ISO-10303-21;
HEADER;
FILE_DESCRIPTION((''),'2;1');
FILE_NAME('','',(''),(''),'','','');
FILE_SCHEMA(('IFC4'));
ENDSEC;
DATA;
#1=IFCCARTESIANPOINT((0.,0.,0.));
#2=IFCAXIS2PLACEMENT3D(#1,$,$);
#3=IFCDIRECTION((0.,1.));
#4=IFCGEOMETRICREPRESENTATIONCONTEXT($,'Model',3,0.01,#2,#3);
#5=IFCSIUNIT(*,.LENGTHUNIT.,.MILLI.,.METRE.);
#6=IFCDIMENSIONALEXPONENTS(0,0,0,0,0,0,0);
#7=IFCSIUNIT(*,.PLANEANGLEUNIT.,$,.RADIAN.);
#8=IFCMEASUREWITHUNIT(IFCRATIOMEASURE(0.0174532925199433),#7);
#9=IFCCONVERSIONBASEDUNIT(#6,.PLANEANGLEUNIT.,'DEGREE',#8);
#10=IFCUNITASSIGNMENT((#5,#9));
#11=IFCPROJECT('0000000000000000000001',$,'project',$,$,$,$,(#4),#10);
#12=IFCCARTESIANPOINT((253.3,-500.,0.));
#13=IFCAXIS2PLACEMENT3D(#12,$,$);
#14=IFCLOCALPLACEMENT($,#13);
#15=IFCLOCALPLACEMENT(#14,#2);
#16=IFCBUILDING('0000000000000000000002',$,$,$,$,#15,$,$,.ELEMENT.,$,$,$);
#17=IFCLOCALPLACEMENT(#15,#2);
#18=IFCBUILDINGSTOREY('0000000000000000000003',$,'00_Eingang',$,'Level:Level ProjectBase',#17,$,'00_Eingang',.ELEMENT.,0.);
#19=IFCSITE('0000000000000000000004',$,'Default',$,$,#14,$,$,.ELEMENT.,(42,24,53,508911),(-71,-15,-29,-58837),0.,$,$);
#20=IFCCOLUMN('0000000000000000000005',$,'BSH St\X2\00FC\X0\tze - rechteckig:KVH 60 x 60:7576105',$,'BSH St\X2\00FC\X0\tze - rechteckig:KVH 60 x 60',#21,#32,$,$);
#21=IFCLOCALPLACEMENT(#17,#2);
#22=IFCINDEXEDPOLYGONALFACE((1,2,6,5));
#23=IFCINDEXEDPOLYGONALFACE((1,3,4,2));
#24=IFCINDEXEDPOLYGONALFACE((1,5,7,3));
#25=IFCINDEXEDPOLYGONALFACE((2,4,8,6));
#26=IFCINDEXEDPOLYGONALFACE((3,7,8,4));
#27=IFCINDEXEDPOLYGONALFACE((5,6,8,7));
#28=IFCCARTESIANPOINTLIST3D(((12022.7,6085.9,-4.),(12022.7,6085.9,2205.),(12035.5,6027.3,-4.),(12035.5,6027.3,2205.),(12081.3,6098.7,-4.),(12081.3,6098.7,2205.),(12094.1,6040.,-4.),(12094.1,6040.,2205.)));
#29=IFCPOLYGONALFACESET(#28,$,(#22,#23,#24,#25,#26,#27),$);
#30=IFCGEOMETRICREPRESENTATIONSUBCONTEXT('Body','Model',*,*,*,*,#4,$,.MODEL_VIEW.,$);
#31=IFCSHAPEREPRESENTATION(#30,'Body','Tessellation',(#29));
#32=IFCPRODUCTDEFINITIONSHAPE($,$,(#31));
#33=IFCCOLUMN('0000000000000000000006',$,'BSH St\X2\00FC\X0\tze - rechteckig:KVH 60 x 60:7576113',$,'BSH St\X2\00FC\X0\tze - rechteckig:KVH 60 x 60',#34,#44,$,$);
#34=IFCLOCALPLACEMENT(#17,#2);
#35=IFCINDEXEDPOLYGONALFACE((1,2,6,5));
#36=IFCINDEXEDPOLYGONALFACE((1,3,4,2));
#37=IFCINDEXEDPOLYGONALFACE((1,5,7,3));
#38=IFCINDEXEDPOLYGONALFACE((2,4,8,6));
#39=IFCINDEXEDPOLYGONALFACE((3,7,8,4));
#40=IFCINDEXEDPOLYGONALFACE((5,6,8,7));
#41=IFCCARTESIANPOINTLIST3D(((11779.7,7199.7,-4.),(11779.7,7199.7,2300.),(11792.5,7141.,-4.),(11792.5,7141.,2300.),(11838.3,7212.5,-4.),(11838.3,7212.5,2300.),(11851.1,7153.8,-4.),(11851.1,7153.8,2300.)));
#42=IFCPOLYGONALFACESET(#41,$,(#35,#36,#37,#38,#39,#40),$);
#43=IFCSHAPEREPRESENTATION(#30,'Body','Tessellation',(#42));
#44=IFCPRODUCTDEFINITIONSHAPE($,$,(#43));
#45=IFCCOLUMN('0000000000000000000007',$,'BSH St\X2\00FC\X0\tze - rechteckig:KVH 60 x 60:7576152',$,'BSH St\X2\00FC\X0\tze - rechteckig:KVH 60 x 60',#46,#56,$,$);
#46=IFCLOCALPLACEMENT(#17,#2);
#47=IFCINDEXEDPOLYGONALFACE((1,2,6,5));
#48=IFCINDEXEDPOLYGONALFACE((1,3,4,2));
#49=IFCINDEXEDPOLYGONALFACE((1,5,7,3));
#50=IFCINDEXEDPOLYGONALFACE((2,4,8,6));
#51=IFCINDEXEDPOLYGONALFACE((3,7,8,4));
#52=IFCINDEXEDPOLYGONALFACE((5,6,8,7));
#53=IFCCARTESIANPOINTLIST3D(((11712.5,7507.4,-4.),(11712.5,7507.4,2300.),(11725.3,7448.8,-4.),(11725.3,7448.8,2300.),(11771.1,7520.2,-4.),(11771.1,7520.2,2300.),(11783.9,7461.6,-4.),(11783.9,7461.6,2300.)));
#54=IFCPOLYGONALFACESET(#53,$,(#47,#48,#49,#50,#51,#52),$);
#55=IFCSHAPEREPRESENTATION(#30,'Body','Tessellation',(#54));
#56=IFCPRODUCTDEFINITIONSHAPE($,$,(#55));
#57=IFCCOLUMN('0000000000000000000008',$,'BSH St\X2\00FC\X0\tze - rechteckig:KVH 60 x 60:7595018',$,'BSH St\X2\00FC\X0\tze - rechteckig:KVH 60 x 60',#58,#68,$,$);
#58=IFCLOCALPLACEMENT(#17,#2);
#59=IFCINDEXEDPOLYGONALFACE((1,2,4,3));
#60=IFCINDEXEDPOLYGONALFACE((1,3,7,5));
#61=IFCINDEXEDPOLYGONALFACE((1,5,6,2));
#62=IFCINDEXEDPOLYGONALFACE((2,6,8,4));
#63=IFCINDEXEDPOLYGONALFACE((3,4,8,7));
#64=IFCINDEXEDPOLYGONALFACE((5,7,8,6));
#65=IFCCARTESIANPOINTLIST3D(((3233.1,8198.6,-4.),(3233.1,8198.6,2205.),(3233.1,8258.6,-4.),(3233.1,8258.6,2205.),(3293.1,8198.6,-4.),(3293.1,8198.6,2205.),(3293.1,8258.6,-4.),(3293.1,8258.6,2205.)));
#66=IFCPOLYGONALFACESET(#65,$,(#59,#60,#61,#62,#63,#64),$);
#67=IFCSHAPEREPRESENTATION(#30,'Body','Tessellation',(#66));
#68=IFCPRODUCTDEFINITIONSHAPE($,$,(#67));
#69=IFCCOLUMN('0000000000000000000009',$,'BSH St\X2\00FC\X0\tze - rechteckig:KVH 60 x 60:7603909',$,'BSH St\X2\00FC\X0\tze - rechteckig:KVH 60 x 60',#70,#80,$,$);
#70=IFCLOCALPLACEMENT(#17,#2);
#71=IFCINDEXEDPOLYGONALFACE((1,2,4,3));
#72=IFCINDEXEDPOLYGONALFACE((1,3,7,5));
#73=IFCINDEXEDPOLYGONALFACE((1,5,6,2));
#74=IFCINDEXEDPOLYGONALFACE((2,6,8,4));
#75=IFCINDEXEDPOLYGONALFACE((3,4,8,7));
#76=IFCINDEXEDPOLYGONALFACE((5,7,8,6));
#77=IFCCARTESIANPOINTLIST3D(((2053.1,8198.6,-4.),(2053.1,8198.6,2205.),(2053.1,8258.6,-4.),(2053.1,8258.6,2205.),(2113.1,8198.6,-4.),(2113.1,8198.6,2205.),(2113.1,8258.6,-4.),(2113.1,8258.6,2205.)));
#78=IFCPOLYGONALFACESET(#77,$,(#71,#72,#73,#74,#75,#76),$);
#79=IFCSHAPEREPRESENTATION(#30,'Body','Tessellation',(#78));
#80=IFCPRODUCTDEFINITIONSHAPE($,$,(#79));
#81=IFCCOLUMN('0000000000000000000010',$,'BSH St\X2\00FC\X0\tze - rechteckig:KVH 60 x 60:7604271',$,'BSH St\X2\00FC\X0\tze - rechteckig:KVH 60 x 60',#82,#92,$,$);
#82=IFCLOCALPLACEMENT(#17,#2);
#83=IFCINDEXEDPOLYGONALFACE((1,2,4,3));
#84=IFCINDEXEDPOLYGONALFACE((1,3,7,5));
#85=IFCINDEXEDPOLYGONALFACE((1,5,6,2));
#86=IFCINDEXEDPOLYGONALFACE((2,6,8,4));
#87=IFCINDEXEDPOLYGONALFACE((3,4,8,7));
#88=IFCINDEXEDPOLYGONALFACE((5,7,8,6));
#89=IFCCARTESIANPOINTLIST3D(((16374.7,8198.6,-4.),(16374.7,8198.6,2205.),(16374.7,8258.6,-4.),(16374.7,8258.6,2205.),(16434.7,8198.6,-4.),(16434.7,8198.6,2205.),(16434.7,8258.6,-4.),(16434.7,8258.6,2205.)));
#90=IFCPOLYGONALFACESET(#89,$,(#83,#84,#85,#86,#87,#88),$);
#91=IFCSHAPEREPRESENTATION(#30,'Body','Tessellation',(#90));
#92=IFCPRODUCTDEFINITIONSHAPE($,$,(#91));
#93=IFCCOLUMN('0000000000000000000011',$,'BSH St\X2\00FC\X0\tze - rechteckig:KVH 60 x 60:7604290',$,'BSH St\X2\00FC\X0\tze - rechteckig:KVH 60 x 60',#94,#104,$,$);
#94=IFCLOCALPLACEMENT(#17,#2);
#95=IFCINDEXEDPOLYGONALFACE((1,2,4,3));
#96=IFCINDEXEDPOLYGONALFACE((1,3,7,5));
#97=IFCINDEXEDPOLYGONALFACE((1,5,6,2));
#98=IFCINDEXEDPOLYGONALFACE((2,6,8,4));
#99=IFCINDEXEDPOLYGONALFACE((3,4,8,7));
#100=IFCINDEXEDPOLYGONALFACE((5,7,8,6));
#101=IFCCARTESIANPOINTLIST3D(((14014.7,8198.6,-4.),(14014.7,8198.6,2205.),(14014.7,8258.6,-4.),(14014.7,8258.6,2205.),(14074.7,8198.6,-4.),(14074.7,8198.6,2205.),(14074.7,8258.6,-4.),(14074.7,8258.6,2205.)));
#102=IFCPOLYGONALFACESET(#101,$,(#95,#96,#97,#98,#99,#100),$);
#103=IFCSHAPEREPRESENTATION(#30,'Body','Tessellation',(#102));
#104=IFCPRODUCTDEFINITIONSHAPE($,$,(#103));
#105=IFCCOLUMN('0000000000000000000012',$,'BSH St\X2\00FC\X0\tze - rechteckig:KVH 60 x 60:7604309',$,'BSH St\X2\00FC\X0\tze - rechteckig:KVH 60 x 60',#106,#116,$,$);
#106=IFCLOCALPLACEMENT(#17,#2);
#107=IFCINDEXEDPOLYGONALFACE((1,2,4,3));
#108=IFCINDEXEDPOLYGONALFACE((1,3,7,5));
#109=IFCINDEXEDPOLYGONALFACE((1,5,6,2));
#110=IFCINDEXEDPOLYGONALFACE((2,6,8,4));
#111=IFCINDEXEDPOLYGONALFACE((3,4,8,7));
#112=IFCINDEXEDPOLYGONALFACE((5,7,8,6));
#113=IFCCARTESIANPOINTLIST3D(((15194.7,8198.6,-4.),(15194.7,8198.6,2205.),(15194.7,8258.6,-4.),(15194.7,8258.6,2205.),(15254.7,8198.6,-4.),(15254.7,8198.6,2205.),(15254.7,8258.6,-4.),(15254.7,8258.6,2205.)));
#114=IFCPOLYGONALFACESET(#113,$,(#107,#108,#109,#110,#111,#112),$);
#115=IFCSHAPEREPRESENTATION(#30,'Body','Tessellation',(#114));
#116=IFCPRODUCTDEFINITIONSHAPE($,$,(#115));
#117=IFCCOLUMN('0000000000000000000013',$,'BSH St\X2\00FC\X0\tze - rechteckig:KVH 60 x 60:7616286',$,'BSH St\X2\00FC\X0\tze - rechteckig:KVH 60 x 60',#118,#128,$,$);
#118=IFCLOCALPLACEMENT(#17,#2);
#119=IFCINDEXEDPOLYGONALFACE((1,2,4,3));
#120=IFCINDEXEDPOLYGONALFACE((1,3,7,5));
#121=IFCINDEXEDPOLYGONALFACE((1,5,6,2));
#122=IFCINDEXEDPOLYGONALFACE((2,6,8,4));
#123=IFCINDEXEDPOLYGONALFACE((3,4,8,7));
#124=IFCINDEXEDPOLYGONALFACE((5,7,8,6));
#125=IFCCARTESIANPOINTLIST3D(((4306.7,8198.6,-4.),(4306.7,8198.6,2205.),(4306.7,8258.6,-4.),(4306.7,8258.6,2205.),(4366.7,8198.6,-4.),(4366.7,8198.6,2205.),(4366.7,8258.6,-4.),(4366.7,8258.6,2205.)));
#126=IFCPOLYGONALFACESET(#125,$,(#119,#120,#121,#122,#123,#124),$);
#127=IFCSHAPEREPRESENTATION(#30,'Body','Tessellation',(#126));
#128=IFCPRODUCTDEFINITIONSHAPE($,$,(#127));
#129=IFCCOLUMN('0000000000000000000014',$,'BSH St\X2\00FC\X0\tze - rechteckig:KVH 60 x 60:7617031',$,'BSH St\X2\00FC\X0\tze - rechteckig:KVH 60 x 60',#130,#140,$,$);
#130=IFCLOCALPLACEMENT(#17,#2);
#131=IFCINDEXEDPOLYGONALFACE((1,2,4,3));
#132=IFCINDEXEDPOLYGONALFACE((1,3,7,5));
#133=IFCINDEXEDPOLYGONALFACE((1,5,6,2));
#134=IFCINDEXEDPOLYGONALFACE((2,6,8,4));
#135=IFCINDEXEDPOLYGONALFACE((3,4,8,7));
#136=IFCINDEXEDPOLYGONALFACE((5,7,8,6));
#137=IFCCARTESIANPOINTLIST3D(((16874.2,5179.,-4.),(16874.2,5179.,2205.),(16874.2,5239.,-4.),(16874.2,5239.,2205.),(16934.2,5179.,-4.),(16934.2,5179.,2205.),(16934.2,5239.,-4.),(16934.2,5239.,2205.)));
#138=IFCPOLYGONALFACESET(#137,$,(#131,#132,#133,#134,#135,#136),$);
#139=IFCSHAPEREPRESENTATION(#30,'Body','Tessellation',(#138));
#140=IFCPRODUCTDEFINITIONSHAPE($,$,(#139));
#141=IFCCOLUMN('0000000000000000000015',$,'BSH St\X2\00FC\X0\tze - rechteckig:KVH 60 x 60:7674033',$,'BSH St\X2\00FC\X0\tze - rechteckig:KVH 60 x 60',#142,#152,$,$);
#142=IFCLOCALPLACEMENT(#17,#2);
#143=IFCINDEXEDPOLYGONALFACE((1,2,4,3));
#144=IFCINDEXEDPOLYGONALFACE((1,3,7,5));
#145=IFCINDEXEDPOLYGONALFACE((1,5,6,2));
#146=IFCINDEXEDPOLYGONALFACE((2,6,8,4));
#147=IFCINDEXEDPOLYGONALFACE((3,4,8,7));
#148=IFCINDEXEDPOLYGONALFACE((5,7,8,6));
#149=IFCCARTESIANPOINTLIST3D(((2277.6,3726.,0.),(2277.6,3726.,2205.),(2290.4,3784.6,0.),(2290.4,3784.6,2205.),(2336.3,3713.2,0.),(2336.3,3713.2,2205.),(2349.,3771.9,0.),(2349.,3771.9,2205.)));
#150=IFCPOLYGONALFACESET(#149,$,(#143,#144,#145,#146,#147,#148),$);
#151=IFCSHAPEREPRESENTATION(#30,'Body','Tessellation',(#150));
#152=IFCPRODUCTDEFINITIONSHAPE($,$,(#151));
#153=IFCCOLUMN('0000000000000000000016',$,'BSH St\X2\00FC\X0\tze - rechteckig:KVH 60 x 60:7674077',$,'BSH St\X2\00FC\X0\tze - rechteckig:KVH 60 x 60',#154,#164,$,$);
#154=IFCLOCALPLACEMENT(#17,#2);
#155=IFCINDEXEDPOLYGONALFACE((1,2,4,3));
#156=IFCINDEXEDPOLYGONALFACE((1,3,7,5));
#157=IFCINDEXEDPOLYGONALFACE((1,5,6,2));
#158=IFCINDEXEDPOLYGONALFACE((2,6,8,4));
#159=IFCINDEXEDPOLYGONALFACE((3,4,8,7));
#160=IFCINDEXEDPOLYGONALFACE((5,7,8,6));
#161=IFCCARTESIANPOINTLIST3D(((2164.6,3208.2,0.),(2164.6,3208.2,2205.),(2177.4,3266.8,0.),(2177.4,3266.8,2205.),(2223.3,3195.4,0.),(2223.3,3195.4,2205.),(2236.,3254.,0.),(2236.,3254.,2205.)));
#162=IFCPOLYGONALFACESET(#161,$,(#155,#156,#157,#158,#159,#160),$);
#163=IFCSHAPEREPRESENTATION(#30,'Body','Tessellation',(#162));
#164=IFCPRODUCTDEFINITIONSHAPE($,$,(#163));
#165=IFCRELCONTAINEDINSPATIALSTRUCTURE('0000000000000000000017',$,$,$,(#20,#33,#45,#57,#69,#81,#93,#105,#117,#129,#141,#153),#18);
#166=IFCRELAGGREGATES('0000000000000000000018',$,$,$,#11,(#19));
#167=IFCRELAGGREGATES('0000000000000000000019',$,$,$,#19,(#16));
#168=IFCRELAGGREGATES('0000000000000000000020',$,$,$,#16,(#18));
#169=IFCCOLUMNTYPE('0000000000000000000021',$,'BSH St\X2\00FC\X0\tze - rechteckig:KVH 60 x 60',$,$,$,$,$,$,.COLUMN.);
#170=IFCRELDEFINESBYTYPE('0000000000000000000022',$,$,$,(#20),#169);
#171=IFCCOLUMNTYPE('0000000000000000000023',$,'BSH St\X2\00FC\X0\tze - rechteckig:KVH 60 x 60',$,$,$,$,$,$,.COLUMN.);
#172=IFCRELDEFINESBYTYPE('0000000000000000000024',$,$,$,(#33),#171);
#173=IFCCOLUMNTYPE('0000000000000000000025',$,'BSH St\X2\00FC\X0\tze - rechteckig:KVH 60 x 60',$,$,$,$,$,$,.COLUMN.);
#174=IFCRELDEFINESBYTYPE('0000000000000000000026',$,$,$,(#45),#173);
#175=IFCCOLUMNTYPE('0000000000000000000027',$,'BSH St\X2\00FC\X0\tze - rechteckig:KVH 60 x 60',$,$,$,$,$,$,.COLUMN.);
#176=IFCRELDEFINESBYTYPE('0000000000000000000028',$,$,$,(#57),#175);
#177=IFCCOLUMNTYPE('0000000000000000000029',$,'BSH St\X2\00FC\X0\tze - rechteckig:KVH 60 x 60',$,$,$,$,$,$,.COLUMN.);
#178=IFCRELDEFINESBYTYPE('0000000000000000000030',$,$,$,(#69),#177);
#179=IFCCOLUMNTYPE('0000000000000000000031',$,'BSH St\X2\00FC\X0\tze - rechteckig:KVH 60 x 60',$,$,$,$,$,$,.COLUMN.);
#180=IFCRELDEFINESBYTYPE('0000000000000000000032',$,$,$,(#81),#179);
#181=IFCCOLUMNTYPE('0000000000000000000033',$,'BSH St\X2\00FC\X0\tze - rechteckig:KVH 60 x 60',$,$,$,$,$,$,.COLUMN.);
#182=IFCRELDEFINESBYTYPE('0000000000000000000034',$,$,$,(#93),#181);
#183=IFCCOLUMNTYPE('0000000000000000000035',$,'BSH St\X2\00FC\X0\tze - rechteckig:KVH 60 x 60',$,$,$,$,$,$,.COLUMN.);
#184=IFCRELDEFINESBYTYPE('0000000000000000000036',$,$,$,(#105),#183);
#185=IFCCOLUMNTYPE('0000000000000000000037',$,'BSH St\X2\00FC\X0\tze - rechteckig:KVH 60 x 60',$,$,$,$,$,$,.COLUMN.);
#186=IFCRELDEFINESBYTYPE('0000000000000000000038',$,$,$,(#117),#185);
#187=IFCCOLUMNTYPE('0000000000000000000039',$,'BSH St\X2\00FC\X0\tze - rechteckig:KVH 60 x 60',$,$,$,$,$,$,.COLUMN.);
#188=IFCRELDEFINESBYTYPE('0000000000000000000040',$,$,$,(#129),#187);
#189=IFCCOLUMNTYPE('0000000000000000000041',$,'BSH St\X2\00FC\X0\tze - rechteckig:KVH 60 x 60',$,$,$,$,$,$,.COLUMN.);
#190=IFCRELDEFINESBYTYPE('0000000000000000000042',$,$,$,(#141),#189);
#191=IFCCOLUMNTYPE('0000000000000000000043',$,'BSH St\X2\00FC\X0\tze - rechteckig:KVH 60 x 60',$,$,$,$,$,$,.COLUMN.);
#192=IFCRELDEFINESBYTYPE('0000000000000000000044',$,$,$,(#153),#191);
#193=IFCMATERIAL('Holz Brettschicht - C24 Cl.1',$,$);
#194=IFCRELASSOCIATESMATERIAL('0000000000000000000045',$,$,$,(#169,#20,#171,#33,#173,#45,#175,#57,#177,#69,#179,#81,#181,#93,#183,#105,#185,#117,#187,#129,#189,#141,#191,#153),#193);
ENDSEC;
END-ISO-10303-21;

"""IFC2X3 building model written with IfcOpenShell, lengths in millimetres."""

from ifc_helpers import new_model, entity, si_unit, converted_unit, direction, frame, frame_2d, origin, origin_2d_with_axis, place, context, subcontext, project, spatial, rectangle, extrude, source, transform, mapped, material, type_object, type_shapes, element, save


model = new_model("IFC2X3")

# Units and contexts
model_context = context("Model", 3, precision=0.01, world=origin(), true_north=direction((0.0, 1.0)))
body_context = subcontext(model_context, "Body", "Model", "MODEL_VIEW")
ifc_project = project(units=[si_unit("LENGTHUNIT", "METRE", prefix="MILLI"), converted_unit("PLANEANGLEUNIT", "DEGREE", entity("IfcRatioMeasure", 0.0174532925199433), si_unit("PLANEANGLEUNIT", "RADIAN"), dimensions=[0, 0, 0, 0, 0, 0, 0])], contexts=[model_context])

# Site, building, storey
site_placement = place(None, frame((253.3, -500.0, 0.0)))
site = spatial("IfcSite", under=ifc_project, at=site_placement, Name="Default", CompositionType="ELEMENT", RefLatitude=(42, 24, 53, 508911), RefLongitude=(-71, -15, -29, -58837), RefElevation=0.0)
building_placement = place(site_placement, origin())
building = spatial("IfcBuilding", under=site, at=building_placement, CompositionType="ELEMENT")
storey_placement = place(building_placement, origin())
storey = spatial("IfcBuildingStorey", under=building, at=storey_placement, Name="00_Eingang", ObjectType="Level:Level ProjectBase", LongName="00_Eingang", CompositionType="ELEMENT", Elevation=0.0)

# Columns
ifc_material_1 = material(Name="Holz Brettschicht - C24 Cl.1")
column_type_1 = type_object("IfcColumnType", Name="BSH Stütze - rechteckig:KVH 60 x 60", PredefinedType="COLUMN", material=ifc_material_1)
shared_shape_1 = source(origin(), body_context, "Body", "SweptSolid", [
    extrude(rectangle(XDim=60.0, YDim=60.0, at=origin_2d_with_axis()), frame((12058.4, 6063.0, -4.0), z_axis=(0.0, 0.0, 1.0), x_axis=(-0.213201, 0.977008, 0.0)), (0.0, 0.0, 1.0), 2209.0),
])
type_shapes(column_type_1, [shared_shape_1])
column_1_placement = place(storey_placement, origin())
element("IfcColumn", 1, at=column_1_placement, inside=storey, type_object=column_type_1, material=ifc_material_1, Name="BSH Stütze - rechteckig:KVH 60 x 60:7576105", ObjectType="BSH Stütze - rechteckig:KVH 60 x 60", context=body_context, shape_type="MappedRepresentation", body=[
    mapped(shared_shape_1, transform((0.0, 0.0, 0.0), scale=1.0)),
])
column_type_2 = type_object("IfcColumnType", Name="BSH Stütze - rechteckig:KVH 60 x 60", PredefinedType="COLUMN", material=ifc_material_1)
shared_shape_2 = source(origin(), body_context, "Body", "SweptSolid", [
    extrude(rectangle(XDim=60.0, YDim=60.0, at=frame_2d((0.0, 0.0), x_axis=(1.0, 0.0))), frame((11815.4, 7176.8, -4.0), z_axis=(0.0, 0.0, 1.0), x_axis=(-0.213201, 0.977008, 0.0)), (0.0, 0.0, 1.0), 2304.0),
])
type_shapes(column_type_2, [shared_shape_2])
column_2_placement = place(storey_placement, origin())
element("IfcColumn", 2, at=column_2_placement, inside=storey, type_object=column_type_2, material=ifc_material_1, Name="BSH Stütze - rechteckig:KVH 60 x 60:7576113", ObjectType="BSH Stütze - rechteckig:KVH 60 x 60", context=body_context, shape_type="MappedRepresentation", body=[
    mapped(shared_shape_2, transform((0.0, 0.0, 0.0), scale=1.0)),
])
column_type_3 = type_object("IfcColumnType", Name="BSH Stütze - rechteckig:KVH 60 x 60", PredefinedType="COLUMN", material=ifc_material_1)
shared_shape_3 = source(origin(), body_context, "Body", "SweptSolid", [
    extrude(rectangle(XDim=60.0, YDim=60.0, at=origin_2d_with_axis()), frame((11748.2, 7484.5, -4.0), z_axis=(0.0, 0.0, 1.0), x_axis=(-0.213201, 0.977008, 0.0)), (0.0, 0.0, 1.0), 2304.0),
])
type_shapes(column_type_3, [shared_shape_3])
column_3_placement = place(storey_placement, origin())
element("IfcColumn", 3, at=column_3_placement, inside=storey, type_object=column_type_3, material=ifc_material_1, Name="BSH Stütze - rechteckig:KVH 60 x 60:7576152", ObjectType="BSH Stütze - rechteckig:KVH 60 x 60", context=body_context, shape_type="MappedRepresentation", body=[
    mapped(shared_shape_3, transform((0.0, 0.0, 0.0), scale=1.0)),
])
column_type_4 = type_object("IfcColumnType", Name="BSH Stütze - rechteckig:KVH 60 x 60", PredefinedType="COLUMN", material=ifc_material_1)
shared_shape_4 = source(origin(), body_context, "Body", "SweptSolid", [
    extrude(rectangle(XDim=60.0, YDim=60.0, at=frame_2d((0.0, 0.0), x_axis=(1.0, 0.0))), frame((3263.1, 8228.6, -4.0), z_axis=(0.0, 0.0, 1.0), x_axis=(0.0, -1.0, 0.0)), (0.0, 0.0, 1.0), 2209.0),
])
type_shapes(column_type_4, [shared_shape_4])
column_4_placement = place(storey_placement, origin())
element("IfcColumn", 4, at=column_4_placement, inside=storey, type_object=column_type_4, material=ifc_material_1, Name="BSH Stütze - rechteckig:KVH 60 x 60:7595018", ObjectType="BSH Stütze - rechteckig:KVH 60 x 60", context=body_context, shape_type="MappedRepresentation", body=[
    mapped(shared_shape_4, transform((0.0, 0.0, 0.0), scale=1.0)),
])
column_type_5 = type_object("IfcColumnType", Name="BSH Stütze - rechteckig:KVH 60 x 60", PredefinedType="COLUMN", material=ifc_material_1)
shared_shape_5 = source(origin(), body_context, "Body", "SweptSolid", [
    extrude(rectangle(XDim=60.0, YDim=60.0, at=frame_2d((0.0, 0.0), x_axis=(1.0, 0.0))), frame((2083.1, 8228.6, -4.0), z_axis=(0.0, 0.0, 1.0), x_axis=(0.0, -1.0, 0.0)), (0.0, 0.0, 1.0), 2209.0),
])
type_shapes(column_type_5, [shared_shape_5])
column_5_placement = place(storey_placement, origin())
element("IfcColumn", 5, at=column_5_placement, inside=storey, type_object=column_type_5, material=ifc_material_1, Name="BSH Stütze - rechteckig:KVH 60 x 60:7603909", ObjectType="BSH Stütze - rechteckig:KVH 60 x 60", context=body_context, shape_type="MappedRepresentation", body=[
    mapped(shared_shape_5, transform((0.0, 0.0, 0.0), scale=1.0)),
])
column_type_6 = type_object("IfcColumnType", Name="BSH Stütze - rechteckig:KVH 60 x 60", PredefinedType="COLUMN", material=ifc_material_1)
shared_shape_6 = source(origin(), body_context, "Body", "SweptSolid", [
    extrude(rectangle(XDim=60.0, YDim=60.0, at=origin_2d_with_axis()), frame((16404.7, 8228.6, -4.0), z_axis=(0.0, 0.0, 1.0), x_axis=(0.0, -1.0, 0.0)), (0.0, 0.0, 1.0), 2209.0),
])
type_shapes(column_type_6, [shared_shape_6])
column_6_placement = place(storey_placement, origin())
element("IfcColumn", 6, at=column_6_placement, inside=storey, type_object=column_type_6, material=ifc_material_1, Name="BSH Stütze - rechteckig:KVH 60 x 60:7604271", ObjectType="BSH Stütze - rechteckig:KVH 60 x 60", context=body_context, shape_type="MappedRepresentation", body=[
    mapped(shared_shape_6, transform((0.0, 0.0, 0.0), scale=1.0)),
])
column_type_7 = type_object("IfcColumnType", Name="BSH Stütze - rechteckig:KVH 60 x 60", PredefinedType="COLUMN", material=ifc_material_1)
shared_shape_7 = source(origin(), body_context, "Body", "SweptSolid", [
    extrude(rectangle(XDim=60.0, YDim=60.0, at=origin_2d_with_axis()), frame((14044.7, 8228.6, -4.0), z_axis=(0.0, 0.0, 1.0), x_axis=(0.0, -1.0, 0.0)), (0.0, 0.0, 1.0), 2209.0),
])
type_shapes(column_type_7, [shared_shape_7])
column_7_placement = place(storey_placement, origin())
element("IfcColumn", 7, at=column_7_placement, inside=storey, type_object=column_type_7, material=ifc_material_1, Name="BSH Stütze - rechteckig:KVH 60 x 60:7604290", ObjectType="BSH Stütze - rechteckig:KVH 60 x 60", context=body_context, shape_type="MappedRepresentation", body=[
    mapped(shared_shape_7, transform((0.0, 0.0, 0.0), scale=1.0)),
])
column_type_8 = type_object("IfcColumnType", Name="BSH Stütze - rechteckig:KVH 60 x 60", PredefinedType="COLUMN", material=ifc_material_1)
shared_shape_8 = source(origin(), body_context, "Body", "SweptSolid", [
    extrude(rectangle(XDim=60.0, YDim=60.0, at=origin_2d_with_axis()), frame((15224.7, 8228.6, -4.0), z_axis=(0.0, 0.0, 1.0), x_axis=(0.0, -1.0, 0.0)), (0.0, 0.0, 1.0), 2209.0),
])
type_shapes(column_type_8, [shared_shape_8])
column_8_placement = place(storey_placement, origin())
element("IfcColumn", 8, at=column_8_placement, inside=storey, type_object=column_type_8, material=ifc_material_1, Name="BSH Stütze - rechteckig:KVH 60 x 60:7604309", ObjectType="BSH Stütze - rechteckig:KVH 60 x 60", context=body_context, shape_type="MappedRepresentation", body=[
    mapped(shared_shape_8, transform((0.0, 0.0, 0.0), scale=1.0)),
])
column_type_9 = type_object("IfcColumnType", Name="BSH Stütze - rechteckig:KVH 60 x 60", PredefinedType="COLUMN", material=ifc_material_1)
shared_shape_9 = source(origin(), body_context, "Body", "SweptSolid", [
    extrude(rectangle(XDim=60.0, YDim=60.0, at=frame_2d((0.0, 0.0), x_axis=(1.0, 0.0))), frame((4336.7, 8228.6, -4.0), z_axis=(0.0, 0.0, 1.0), x_axis=(0.0, -1.0, 0.0)), (0.0, 0.0, 1.0), 2209.0),
])
type_shapes(column_type_9, [shared_shape_9])
column_9_placement = place(storey_placement, origin())
element("IfcColumn", 9, at=column_9_placement, inside=storey, type_object=column_type_9, material=ifc_material_1, Name="BSH Stütze - rechteckig:KVH 60 x 60:7616286", ObjectType="BSH Stütze - rechteckig:KVH 60 x 60", context=body_context, shape_type="MappedRepresentation", body=[
    mapped(shared_shape_9, transform((0.0, 0.0, 0.0), scale=1.0)),
])
column_type_10 = type_object("IfcColumnType", Name="BSH Stütze - rechteckig:KVH 60 x 60", PredefinedType="COLUMN", material=ifc_material_1)
shared_shape_10 = source(origin(), body_context, "Body", "SweptSolid", [
    extrude(rectangle(XDim=60.0, YDim=60.0, at=frame_2d((0.0, 0.0), x_axis=(1.0, 0.0))), frame((16904.2, 5209.0, -4.0), z_axis=(0.0, 0.0, 1.0), x_axis=(0.0, -1.0, 0.0)), (0.0, 0.0, 1.0), 2209.0),
])
type_shapes(column_type_10, [shared_shape_10])
column_10_placement = place(storey_placement, origin())
element("IfcColumn", 10, at=column_10_placement, inside=storey, type_object=column_type_10, material=ifc_material_1, Name="BSH Stütze - rechteckig:KVH 60 x 60:7617031", ObjectType="BSH Stütze - rechteckig:KVH 60 x 60", context=body_context, shape_type="MappedRepresentation", body=[
    mapped(shared_shape_10, transform((0.0, 0.0, 0.0), scale=1.0)),
])
column_type_11 = type_object("IfcColumnType", Name="BSH Stütze - rechteckig:KVH 60 x 60", PredefinedType="COLUMN", material=ifc_material_1)
shared_shape_11 = source(origin(), body_context, "Body", "SweptSolid", [
    extrude(rectangle(XDim=60.0, YDim=60.0, at=frame_2d((0.0, 0.0), x_axis=(1.0, 0.0))), frame((2313.3, 3748.9, 0.0), z_axis=(0.0, 0.0, 1.0), x_axis=(0.213201, 0.977008, 0.0)), (0.0, 0.0, 1.0), 2205.0),
])
type_shapes(column_type_11, [shared_shape_11])
column_11_placement = place(storey_placement, origin())
element("IfcColumn", 11, at=column_11_placement, inside=storey, type_object=column_type_11, material=ifc_material_1, Name="BSH Stütze - rechteckig:KVH 60 x 60:7674033", ObjectType="BSH Stütze - rechteckig:KVH 60 x 60", context=body_context, shape_type="MappedRepresentation", body=[
    mapped(shared_shape_11, transform((0.0, 0.0, 0.0), scale=1.0)),
])
column_type_12 = type_object("IfcColumnType", Name="BSH Stütze - rechteckig:KVH 60 x 60", PredefinedType="COLUMN", material=ifc_material_1)
shared_shape_12 = source(origin(), body_context, "Body", "SweptSolid", [
    extrude(rectangle(XDim=60.0, YDim=60.0, at=frame_2d((0.0, 0.0), x_axis=(1.0, 0.0))), frame((2200.3, 3231.1, 0.0), z_axis=(0.0, 0.0, 1.0), x_axis=(0.213201, 0.977008, 0.0)), (0.0, 0.0, 1.0), 2205.0),
])
type_shapes(column_type_12, [shared_shape_12])
column_12_placement = place(storey_placement, origin())
element("IfcColumn", 12, at=column_12_placement, inside=storey, type_object=column_type_12, material=ifc_material_1, Name="BSH Stütze - rechteckig:KVH 60 x 60:7674077", ObjectType="BSH Stütze - rechteckig:KVH 60 x 60", context=body_context, shape_type="MappedRepresentation", body=[
    mapped(shared_shape_12, transform((0.0, 0.0, 0.0), scale=1.0)),
])

save(model, "model.ifc")
